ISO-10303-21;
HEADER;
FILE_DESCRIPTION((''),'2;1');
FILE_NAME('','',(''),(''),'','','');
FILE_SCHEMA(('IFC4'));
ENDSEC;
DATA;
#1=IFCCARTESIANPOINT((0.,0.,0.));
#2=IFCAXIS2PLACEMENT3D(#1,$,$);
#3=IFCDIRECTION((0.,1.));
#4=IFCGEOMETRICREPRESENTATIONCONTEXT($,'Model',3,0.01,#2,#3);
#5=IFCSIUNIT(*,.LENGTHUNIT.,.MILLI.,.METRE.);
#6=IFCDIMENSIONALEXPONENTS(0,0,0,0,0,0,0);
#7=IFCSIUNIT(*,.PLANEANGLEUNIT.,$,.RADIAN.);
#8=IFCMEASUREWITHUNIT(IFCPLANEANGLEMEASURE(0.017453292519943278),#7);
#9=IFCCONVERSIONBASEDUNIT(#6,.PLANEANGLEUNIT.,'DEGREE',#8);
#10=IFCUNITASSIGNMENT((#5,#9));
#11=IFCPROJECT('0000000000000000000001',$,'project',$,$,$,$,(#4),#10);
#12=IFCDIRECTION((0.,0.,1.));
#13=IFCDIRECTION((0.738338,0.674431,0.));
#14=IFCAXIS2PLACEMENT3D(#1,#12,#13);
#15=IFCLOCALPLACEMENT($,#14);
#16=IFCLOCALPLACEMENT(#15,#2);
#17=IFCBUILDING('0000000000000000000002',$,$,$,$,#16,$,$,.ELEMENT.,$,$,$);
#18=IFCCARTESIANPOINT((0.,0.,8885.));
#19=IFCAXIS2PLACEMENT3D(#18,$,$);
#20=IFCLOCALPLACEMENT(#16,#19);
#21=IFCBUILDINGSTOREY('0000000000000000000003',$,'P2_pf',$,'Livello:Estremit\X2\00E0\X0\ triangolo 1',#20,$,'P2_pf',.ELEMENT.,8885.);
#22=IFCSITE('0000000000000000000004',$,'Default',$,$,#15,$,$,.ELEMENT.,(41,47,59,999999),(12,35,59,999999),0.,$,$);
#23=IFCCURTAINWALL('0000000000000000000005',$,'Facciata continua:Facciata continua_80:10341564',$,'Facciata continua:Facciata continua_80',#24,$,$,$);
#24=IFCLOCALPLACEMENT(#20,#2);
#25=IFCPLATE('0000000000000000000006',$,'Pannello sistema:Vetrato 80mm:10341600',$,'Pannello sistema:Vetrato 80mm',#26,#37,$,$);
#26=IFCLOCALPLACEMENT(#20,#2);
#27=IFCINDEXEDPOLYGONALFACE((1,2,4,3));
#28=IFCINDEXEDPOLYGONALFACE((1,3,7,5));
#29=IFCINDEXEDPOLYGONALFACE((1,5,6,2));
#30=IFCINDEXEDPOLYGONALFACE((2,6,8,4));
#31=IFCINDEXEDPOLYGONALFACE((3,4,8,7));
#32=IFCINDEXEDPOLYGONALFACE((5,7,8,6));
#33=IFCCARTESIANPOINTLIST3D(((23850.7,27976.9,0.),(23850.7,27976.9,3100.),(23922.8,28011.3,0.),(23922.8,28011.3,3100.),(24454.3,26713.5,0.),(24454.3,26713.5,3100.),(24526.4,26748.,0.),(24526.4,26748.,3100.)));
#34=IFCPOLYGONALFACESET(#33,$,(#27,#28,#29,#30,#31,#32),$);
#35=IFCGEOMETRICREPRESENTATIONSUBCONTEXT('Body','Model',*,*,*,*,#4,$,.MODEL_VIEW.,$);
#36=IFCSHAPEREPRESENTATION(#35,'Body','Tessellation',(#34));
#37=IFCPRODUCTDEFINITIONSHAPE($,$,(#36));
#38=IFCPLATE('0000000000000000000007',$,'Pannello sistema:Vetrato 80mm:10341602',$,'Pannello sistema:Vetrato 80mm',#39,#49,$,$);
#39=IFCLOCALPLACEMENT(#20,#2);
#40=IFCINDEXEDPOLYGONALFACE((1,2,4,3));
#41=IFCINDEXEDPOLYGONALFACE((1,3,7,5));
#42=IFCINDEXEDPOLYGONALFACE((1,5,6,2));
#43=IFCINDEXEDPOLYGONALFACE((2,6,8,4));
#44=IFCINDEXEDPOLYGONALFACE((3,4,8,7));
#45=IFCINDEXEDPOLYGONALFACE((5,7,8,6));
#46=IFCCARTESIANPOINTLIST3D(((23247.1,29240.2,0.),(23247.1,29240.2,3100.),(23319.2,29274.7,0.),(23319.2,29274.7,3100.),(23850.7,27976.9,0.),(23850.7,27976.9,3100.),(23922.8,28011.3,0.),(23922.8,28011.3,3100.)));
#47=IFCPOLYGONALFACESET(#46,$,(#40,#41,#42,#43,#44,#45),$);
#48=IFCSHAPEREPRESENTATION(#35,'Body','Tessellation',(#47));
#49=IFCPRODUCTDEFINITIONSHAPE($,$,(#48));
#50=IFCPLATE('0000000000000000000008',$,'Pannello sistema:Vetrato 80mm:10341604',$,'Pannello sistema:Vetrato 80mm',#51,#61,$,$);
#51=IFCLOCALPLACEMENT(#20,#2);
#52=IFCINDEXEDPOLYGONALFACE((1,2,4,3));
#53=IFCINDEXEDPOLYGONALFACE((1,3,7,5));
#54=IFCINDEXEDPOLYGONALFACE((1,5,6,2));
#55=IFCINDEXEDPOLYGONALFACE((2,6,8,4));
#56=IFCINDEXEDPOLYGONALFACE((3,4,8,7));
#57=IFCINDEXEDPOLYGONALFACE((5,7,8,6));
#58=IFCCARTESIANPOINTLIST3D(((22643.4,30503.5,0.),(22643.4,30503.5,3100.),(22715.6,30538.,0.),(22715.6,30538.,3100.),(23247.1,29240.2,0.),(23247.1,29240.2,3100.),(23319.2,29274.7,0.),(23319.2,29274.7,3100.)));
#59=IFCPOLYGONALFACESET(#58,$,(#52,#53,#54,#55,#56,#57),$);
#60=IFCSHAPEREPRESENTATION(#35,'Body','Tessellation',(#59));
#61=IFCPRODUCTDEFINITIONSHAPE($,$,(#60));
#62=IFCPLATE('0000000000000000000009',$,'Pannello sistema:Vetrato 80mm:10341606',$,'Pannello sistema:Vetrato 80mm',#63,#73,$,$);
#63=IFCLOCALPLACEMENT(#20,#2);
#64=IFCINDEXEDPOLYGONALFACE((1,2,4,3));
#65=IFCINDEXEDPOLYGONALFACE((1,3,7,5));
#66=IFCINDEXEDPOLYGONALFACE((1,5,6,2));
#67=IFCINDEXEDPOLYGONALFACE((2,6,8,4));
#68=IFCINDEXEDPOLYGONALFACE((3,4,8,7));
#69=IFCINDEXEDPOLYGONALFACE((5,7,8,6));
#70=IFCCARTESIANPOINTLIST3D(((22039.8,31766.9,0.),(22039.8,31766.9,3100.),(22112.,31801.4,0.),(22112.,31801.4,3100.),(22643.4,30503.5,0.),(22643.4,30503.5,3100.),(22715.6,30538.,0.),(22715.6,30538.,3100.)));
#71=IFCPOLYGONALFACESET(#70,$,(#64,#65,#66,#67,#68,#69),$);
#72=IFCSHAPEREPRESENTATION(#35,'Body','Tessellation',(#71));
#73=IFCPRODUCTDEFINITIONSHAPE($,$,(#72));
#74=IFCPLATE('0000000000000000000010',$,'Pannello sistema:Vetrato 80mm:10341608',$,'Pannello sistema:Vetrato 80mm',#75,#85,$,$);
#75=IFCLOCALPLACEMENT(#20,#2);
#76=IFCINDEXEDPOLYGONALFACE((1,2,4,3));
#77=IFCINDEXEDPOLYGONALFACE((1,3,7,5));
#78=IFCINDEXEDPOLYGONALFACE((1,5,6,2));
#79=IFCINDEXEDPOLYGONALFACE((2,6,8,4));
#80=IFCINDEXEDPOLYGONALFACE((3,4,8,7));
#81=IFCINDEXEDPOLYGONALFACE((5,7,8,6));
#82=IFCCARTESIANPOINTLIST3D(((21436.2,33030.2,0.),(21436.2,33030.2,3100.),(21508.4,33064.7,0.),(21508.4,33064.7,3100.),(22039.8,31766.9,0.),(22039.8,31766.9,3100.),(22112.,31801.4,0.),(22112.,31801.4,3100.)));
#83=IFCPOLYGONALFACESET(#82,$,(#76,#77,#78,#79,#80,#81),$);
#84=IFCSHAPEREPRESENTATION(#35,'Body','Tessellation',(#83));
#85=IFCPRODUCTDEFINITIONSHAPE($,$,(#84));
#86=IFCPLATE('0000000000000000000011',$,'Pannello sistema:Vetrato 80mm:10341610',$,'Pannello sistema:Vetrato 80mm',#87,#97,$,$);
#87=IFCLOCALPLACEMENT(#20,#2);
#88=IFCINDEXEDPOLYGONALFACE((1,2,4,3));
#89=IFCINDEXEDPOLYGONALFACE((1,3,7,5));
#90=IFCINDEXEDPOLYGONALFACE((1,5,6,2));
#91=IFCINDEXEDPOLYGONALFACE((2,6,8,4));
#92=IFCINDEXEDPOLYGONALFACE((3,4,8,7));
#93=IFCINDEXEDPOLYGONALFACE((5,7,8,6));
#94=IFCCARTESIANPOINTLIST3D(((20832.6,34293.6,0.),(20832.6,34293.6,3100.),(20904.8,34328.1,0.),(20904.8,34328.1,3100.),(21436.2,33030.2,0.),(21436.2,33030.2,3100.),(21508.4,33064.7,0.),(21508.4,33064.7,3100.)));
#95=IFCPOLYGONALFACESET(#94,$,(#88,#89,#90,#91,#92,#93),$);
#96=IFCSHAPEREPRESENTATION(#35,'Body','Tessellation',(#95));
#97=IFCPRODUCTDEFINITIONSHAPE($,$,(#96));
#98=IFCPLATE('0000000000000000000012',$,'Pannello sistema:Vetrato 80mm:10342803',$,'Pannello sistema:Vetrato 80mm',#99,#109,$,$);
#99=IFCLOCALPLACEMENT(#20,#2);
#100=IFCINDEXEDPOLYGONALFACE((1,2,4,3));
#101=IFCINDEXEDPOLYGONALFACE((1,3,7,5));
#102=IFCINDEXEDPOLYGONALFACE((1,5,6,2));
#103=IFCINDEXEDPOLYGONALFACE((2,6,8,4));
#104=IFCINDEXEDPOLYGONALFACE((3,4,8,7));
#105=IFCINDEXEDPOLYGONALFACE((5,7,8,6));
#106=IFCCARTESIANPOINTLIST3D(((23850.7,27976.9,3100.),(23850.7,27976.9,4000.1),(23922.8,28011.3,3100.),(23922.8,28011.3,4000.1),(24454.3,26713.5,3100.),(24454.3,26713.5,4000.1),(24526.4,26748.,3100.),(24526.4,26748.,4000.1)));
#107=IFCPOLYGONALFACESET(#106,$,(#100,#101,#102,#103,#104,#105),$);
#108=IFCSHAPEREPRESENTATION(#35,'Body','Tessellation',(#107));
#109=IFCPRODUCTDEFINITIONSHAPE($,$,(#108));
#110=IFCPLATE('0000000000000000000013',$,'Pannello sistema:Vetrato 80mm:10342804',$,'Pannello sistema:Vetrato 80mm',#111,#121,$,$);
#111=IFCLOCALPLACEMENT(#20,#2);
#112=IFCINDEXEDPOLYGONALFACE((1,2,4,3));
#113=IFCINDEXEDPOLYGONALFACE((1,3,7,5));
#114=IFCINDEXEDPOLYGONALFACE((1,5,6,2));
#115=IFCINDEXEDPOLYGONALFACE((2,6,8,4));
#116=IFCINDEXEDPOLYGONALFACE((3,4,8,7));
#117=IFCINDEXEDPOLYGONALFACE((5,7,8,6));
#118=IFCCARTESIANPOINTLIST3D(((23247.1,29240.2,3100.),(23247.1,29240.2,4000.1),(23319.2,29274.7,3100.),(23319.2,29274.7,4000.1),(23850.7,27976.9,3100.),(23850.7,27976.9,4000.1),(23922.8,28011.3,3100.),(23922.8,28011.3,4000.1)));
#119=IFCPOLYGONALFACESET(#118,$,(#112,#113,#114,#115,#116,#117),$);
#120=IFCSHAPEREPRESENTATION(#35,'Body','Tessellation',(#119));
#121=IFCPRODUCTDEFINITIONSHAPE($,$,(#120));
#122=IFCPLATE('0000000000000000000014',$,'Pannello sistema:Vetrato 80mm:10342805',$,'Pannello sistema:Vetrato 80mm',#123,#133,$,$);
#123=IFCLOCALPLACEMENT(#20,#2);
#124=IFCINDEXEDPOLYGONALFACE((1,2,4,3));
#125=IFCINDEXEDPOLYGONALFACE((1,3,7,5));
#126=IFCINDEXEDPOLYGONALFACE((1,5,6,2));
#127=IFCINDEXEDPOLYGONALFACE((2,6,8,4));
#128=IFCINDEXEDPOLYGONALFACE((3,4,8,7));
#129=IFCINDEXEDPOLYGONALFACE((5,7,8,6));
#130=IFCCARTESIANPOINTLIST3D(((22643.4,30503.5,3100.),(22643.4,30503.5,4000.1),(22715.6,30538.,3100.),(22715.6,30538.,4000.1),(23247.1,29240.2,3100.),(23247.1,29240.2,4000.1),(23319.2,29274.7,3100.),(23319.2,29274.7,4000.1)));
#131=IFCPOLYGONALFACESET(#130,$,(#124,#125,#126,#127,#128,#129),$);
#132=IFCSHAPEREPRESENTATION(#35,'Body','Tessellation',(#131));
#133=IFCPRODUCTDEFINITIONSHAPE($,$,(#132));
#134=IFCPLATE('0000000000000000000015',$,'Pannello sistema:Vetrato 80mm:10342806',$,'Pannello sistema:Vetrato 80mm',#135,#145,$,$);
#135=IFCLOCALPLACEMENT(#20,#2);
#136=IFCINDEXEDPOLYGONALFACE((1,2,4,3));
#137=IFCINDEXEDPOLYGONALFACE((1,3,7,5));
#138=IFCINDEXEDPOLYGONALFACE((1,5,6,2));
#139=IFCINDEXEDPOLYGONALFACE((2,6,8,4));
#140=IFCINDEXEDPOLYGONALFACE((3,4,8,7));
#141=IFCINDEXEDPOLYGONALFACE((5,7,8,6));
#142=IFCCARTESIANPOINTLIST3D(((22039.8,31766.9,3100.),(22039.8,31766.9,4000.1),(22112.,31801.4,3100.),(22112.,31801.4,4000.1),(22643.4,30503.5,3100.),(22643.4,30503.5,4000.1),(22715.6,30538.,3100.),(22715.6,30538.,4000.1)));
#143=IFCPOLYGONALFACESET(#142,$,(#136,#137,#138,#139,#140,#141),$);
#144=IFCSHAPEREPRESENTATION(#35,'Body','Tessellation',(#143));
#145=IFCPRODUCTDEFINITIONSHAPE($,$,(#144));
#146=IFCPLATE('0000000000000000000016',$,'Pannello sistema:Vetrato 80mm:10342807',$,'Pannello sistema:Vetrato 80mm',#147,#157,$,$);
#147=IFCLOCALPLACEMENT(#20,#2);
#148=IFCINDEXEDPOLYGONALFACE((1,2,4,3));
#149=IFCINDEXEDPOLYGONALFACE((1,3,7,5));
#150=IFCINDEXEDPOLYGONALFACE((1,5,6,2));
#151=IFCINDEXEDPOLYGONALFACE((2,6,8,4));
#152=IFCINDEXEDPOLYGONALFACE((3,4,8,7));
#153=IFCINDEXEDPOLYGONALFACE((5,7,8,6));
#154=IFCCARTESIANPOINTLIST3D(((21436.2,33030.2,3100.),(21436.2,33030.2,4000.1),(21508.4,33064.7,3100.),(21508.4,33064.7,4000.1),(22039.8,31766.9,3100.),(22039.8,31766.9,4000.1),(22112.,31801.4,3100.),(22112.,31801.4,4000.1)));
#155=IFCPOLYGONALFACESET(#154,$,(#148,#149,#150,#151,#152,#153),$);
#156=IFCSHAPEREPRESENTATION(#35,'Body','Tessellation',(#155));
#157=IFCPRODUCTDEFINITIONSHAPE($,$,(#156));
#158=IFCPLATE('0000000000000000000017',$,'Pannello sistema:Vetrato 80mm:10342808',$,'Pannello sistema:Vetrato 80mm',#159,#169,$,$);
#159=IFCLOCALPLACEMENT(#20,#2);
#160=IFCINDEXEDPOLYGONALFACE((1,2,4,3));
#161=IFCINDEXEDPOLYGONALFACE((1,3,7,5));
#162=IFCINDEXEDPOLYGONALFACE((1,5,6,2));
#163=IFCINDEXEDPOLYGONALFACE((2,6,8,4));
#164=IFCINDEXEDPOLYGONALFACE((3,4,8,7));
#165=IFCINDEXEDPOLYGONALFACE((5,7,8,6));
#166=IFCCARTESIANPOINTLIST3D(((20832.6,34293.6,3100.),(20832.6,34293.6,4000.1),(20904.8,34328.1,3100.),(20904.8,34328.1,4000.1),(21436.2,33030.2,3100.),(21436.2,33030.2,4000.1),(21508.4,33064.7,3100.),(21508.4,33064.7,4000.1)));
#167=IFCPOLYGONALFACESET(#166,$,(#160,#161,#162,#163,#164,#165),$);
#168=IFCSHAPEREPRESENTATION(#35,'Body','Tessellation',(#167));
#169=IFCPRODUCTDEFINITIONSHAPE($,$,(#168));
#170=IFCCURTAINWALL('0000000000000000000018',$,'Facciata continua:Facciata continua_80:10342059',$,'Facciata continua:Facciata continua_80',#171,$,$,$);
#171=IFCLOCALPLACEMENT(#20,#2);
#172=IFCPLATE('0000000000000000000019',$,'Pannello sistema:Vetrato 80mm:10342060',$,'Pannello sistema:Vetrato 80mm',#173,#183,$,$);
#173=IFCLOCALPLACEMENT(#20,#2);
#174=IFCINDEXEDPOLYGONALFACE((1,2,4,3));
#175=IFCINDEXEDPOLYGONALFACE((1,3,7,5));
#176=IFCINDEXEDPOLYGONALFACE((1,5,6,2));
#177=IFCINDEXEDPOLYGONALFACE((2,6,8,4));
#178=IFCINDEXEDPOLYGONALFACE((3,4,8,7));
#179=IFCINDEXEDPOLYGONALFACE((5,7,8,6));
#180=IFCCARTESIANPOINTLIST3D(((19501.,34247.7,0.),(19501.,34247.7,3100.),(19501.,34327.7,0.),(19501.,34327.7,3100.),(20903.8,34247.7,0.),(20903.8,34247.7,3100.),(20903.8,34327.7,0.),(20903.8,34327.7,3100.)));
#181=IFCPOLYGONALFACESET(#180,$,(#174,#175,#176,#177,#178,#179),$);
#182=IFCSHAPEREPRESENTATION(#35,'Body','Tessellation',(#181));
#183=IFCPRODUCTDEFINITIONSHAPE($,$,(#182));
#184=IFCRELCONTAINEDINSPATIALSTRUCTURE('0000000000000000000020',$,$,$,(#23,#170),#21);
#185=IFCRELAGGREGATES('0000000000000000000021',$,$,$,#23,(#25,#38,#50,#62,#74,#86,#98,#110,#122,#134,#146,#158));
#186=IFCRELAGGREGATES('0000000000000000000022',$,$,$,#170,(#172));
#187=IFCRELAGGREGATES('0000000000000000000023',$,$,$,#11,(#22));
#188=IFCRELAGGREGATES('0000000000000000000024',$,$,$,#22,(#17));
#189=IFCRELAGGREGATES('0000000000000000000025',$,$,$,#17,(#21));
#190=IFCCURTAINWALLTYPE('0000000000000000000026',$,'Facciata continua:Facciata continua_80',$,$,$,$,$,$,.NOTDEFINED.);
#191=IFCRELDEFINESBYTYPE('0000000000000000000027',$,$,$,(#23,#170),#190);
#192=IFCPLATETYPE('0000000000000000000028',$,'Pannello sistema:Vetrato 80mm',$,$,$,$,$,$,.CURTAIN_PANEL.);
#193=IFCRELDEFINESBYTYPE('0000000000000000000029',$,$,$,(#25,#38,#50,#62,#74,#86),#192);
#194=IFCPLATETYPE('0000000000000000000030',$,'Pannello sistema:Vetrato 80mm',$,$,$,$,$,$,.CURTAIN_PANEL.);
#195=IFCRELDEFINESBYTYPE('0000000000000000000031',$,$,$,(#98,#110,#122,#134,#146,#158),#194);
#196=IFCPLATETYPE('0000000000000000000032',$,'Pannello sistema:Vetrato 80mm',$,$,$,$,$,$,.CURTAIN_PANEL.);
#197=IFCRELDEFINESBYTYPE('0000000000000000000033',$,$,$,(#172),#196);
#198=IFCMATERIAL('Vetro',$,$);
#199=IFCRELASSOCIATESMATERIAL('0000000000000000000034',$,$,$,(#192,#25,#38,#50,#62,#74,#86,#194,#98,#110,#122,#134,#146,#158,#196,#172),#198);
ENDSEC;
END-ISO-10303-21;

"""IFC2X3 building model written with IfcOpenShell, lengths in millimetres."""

from ifc_helpers import new_model, entity, si_unit, converted_unit, direction, frame, frame_2d, origin, origin_2d_with_axis, place, context, subcontext, project, spatial, rectangle, extrude, source, transform, mapped, material, type_object, type_shapes, element, aggregate, save


model = new_model("IFC2X3")

# Units and contexts
model_context = context("Model", 3, precision=0.01, world=origin(), true_north=direction((0.0, 1.0)))
body_context = subcontext(model_context, "Body", "Model", "MODEL_VIEW")
ifc_project = project(units=[si_unit("LENGTHUNIT", "METRE", prefix="MILLI"), converted_unit("PLANEANGLEUNIT", "DEGREE", entity("IfcPlaneAngleMeasure", 0.017453292519943278), si_unit("PLANEANGLEUNIT", "RADIAN"), dimensions=[0, 0, 0, 0, 0, 0, 0])], contexts=[model_context])

# Site, building, storey
site_placement = place(None, frame((0.0, 0.0, 0.0), z_axis=(0.0, 0.0, 1.0), x_axis=(0.738338, 0.674431, 0.0)))
site = spatial("IfcSite", under=ifc_project, at=site_placement, Name="Default", CompositionType="ELEMENT", RefLatitude=(41, 47, 59, 999999), RefLongitude=(12, 35, 59, 999999), RefElevation=0.0)
building_placement = place(site_placement, origin())
building = spatial("IfcBuilding", under=site, at=building_placement, CompositionType="ELEMENT")
storey_placement = place(building_placement, frame((0.0, 0.0, 8885.0)))
storey = spatial("IfcBuildingStorey", under=building, at=storey_placement, Name="P2_pf", ObjectType="Livello:Estremità triangolo 1", LongName="P2_pf", CompositionType="ELEMENT", Elevation=8885.0)

# Curtain walls, plates
curtain_wall_type = type_object("IfcCurtainWallType", Name="Facciata continua:Facciata continua_80", PredefinedType="NOTDEFINED")
curtain_wall_1_placement = place(storey_placement, frame((0.0, 0.0, -8885.0)))
curtain_wall_1 = element("IfcCurtainWall", 1, at=curtain_wall_1_placement, inside=storey, type_object=curtain_wall_type, Name="Facciata continua:Facciata continua_80:10341564", ObjectType="Facciata continua:Facciata continua_80")
ifc_material_1 = material(Name="Vetro")
plate_type_1 = type_object("IfcPlateType", Name="Pannello sistema:Vetrato 80mm", PredefinedType="CURTAIN_PANEL", material=ifc_material_1)
shared_shape_1 = source(origin(), body_context, "Body", "SweptSolid", [
    extrude(rectangle(XDim=80.0, YDim=1400.1, at=frame_2d((0.0, 0.0), x_axis=(1.0, 0.0))), frame((0.0, -40.0, 0.0), z_axis=(0.0, 0.0, 1.0), x_axis=(0.0, 1.0, 0.0)), (0.0, 0.0, 1.0), 3100.0),
])
type_shapes(plate_type_1, [shared_shape_1])
plate_1_placement = place(curtain_wall_1_placement, frame((24152.5, 27345.2, 8885.0), z_axis=(0.0, 0.0, 1.0), x_axis=(-0.431105, 0.902302, 0.0)))
plate_1 = element("IfcPlate", 2, at=plate_1_placement, type_object=plate_type_1, material=ifc_material_1, Name="Pannello sistema:Vetrato 80mm:10341600", ObjectType="Pannello sistema:Vetrato 80mm", context=body_context, shape_type="MappedRepresentation", body=[
    mapped(shared_shape_1, transform((0.0, 0.0, 0.0), scale=1.0)),
])
plate_2_placement = place(curtain_wall_1_placement, frame((23548.9, 28608.5, 8885.0), z_axis=(0.0, 0.0, 1.0), x_axis=(-0.431105, 0.902302, 0.0)))
plate_2 = element("IfcPlate", 3, at=plate_2_placement, type_object=plate_type_1, material=ifc_material_1, Name="Pannello sistema:Vetrato 80mm:10341602", ObjectType="Pannello sistema:Vetrato 80mm", context=body_context, shape_type="MappedRepresentation", body=[
    mapped(shared_shape_1, transform((0.0, 0.0, 0.0), scale=1.0)),
])
plate_3_placement = place(curtain_wall_1_placement, frame((22945.3, 29871.9, 8885.0), z_axis=(0.0, 0.0, 1.0), x_axis=(-0.431105, 0.902302, 0.0)))
plate_3 = element("IfcPlate", 4, at=plate_3_placement, type_object=plate_type_1, material=ifc_material_1, Name="Pannello sistema:Vetrato 80mm:10341604", ObjectType="Pannello sistema:Vetrato 80mm", context=body_context, shape_type="MappedRepresentation", body=[
    mapped(shared_shape_1, transform((0.0, 0.0, 0.0), scale=1.0)),
])
plate_4_placement = place(curtain_wall_1_placement, frame((22341.6, 31135.2, 8885.0), z_axis=(0.0, 0.0, 1.0), x_axis=(-0.431105, 0.902302, 0.0)))
plate_4 = element("IfcPlate", 5, at=plate_4_placement, type_object=plate_type_1, material=ifc_material_1, Name="Pannello sistema:Vetrato 80mm:10341606", ObjectType="Pannello sistema:Vetrato 80mm", context=body_context, shape_type="MappedRepresentation", body=[
    mapped(shared_shape_1, transform((0.0, 0.0, 0.0), scale=1.0)),
])
plate_5_placement = place(curtain_wall_1_placement, frame((21738.0, 32398.6, 8885.0), z_axis=(0.0, 0.0, 1.0), x_axis=(-0.431105, 0.902302, 0.0)))
plate_5 = element("IfcPlate", 6, at=plate_5_placement, type_object=plate_type_1, material=ifc_material_1, Name="Pannello sistema:Vetrato 80mm:10341608", ObjectType="Pannello sistema:Vetrato 80mm", context=body_context, shape_type="MappedRepresentation", body=[
    mapped(shared_shape_1, transform((0.0, 0.0, 0.0), scale=1.0)),
])
plate_6_placement = place(curtain_wall_1_placement, frame((21134.4, 33661.9, 8885.0), z_axis=(0.0, 0.0, 1.0), x_axis=(-0.431105, 0.902302, 0.0)))
plate_6 = element("IfcPlate", 7, at=plate_6_placement, type_object=plate_type_1, material=ifc_material_1, Name="Pannello sistema:Vetrato 80mm:10341610", ObjectType="Pannello sistema:Vetrato 80mm", context=body_context, shape_type="MappedRepresentation", body=[
    mapped(shared_shape_1, transform((0.0, 0.0, 0.0), scale=1.0)),
])
plate_type_2 = type_object("IfcPlateType", Name="Pannello sistema:Vetrato 80mm", PredefinedType="CURTAIN_PANEL", material=ifc_material_1)
shared_shape_2 = source(origin(), body_context, "Body", "SweptSolid", [
    extrude(rectangle(XDim=80.0, YDim=1400.1, at=frame_2d((0.0, 0.0), x_axis=(1.0, 0.0))), frame((0.0, -40.0, 0.0), z_axis=(0.0, 0.0, 1.0), x_axis=(0.0, 1.0, 0.0)), (0.0, 0.0, 1.0), 900.1),
])
type_shapes(plate_type_2, [shared_shape_2])
plate_7_placement = place(curtain_wall_1_placement, frame((24152.5, 27345.2, 11985.0), z_axis=(0.0, 0.0, 1.0), x_axis=(-0.431105, 0.902302, 0.0)))
plate_7 = element("IfcPlate", 8, at=plate_7_placement, type_object=plate_type_2, material=ifc_material_1, Name="Pannello sistema:Vetrato 80mm:10342803", ObjectType="Pannello sistema:Vetrato 80mm", context=body_context, shape_type="MappedRepresentation", body=[
    mapped(shared_shape_2, transform((0.0, 0.0, 0.0), scale=1.0)),
])
plate_8_placement = place(curtain_wall_1_placement, frame((23548.9, 28608.5, 11985.0), z_axis=(0.0, 0.0, 1.0), x_axis=(-0.431105, 0.902302, 0.0)))
plate_8 = element("IfcPlate", 9, at=plate_8_placement, type_object=plate_type_2, material=ifc_material_1, Name="Pannello sistema:Vetrato 80mm:10342804", ObjectType="Pannello sistema:Vetrato 80mm", context=body_context, shape_type="MappedRepresentation", body=[
    mapped(shared_shape_2, transform((0.0, 0.0, 0.0), scale=1.0)),
])
plate_9_placement = place(curtain_wall_1_placement, frame((22945.3, 29871.9, 11985.0), z_axis=(0.0, 0.0, 1.0), x_axis=(-0.431105, 0.902302, 0.0)))
plate_9 = element("IfcPlate", 10, at=plate_9_placement, type_object=plate_type_2, material=ifc_material_1, Name="Pannello sistema:Vetrato 80mm:10342805", ObjectType="Pannello sistema:Vetrato 80mm", context=body_context, shape_type="MappedRepresentation", body=[
    mapped(shared_shape_2, transform((0.0, 0.0, 0.0), scale=1.0)),
])
plate_10_placement = place(curtain_wall_1_placement, frame((22341.6, 31135.2, 11985.0), z_axis=(0.0, 0.0, 1.0), x_axis=(-0.431105, 0.902302, 0.0)))
plate_10 = element("IfcPlate", 11, at=plate_10_placement, type_object=plate_type_2, material=ifc_material_1, Name="Pannello sistema:Vetrato 80mm:10342806", ObjectType="Pannello sistema:Vetrato 80mm", context=body_context, shape_type="MappedRepresentation", body=[
    mapped(shared_shape_2, transform((0.0, 0.0, 0.0), scale=1.0)),
])
plate_11_placement = place(curtain_wall_1_placement, frame((21738.0, 32398.6, 11985.0), z_axis=(0.0, 0.0, 1.0), x_axis=(-0.431105, 0.902302, 0.0)))
plate_11 = element("IfcPlate", 12, at=plate_11_placement, type_object=plate_type_2, material=ifc_material_1, Name="Pannello sistema:Vetrato 80mm:10342807", ObjectType="Pannello sistema:Vetrato 80mm", context=body_context, shape_type="MappedRepresentation", body=[
    mapped(shared_shape_2, transform((0.0, 0.0, 0.0), scale=1.0)),
])
plate_12_placement = place(curtain_wall_1_placement, frame((21134.4, 33661.9, 11985.0), z_axis=(0.0, 0.0, 1.0), x_axis=(-0.431105, 0.902302, 0.0)))
plate_12 = element("IfcPlate", 13, at=plate_12_placement, type_object=plate_type_2, material=ifc_material_1, Name="Pannello sistema:Vetrato 80mm:10342808", ObjectType="Pannello sistema:Vetrato 80mm", context=body_context, shape_type="MappedRepresentation", body=[
    mapped(shared_shape_2, transform((0.0, 0.0, 0.0), scale=1.0)),
])
aggregate(curtain_wall_1, [plate_1, plate_2, plate_3, plate_4, plate_5, plate_6, plate_7, plate_8, plate_9, plate_10, plate_11, plate_12])
curtain_wall_2_placement = place(storey_placement, frame((0.0, 0.0, -8885.0)))
curtain_wall_2 = element("IfcCurtainWall", 14, at=curtain_wall_2_placement, inside=storey, type_object=curtain_wall_type, Name="Facciata continua:Facciata continua_80:10342059", ObjectType="Facciata continua:Facciata continua_80")
plate_type_3 = type_object("IfcPlateType", Name="Pannello sistema:Vetrato 80mm", PredefinedType="CURTAIN_PANEL", material=ifc_material_1)
shared_shape_3 = source(origin(), body_context, "Body", "SweptSolid", [
    extrude(rectangle(XDim=80.0, YDim=1402.8, at=origin_2d_with_axis()), frame((0.0, -40.0, 0.0), z_axis=(0.0, 0.0, 1.0), x_axis=(0.0, 1.0, 0.0)), (0.0, 0.0, 1.0), 3100.0),
])
type_shapes(plate_type_3, [shared_shape_3])
plate_13_placement = place(curtain_wall_2_placement, frame((20202.4, 34247.7, 8885.0), z_axis=(0.0, 0.0, 1.0), x_axis=(-1.0, 0.0, 0.0)))
plate_13 = element("IfcPlate", 15, at=plate_13_placement, type_object=plate_type_3, material=ifc_material_1, Name="Pannello sistema:Vetrato 80mm:10342060", ObjectType="Pannello sistema:Vetrato 80mm", context=body_context, shape_type="MappedRepresentation", body=[
    mapped(shared_shape_3, transform((0.0, 0.0, 0.0), scale=1.0)),
])
aggregate(curtain_wall_2, [plate_13])

save(model, "model.ifc")
